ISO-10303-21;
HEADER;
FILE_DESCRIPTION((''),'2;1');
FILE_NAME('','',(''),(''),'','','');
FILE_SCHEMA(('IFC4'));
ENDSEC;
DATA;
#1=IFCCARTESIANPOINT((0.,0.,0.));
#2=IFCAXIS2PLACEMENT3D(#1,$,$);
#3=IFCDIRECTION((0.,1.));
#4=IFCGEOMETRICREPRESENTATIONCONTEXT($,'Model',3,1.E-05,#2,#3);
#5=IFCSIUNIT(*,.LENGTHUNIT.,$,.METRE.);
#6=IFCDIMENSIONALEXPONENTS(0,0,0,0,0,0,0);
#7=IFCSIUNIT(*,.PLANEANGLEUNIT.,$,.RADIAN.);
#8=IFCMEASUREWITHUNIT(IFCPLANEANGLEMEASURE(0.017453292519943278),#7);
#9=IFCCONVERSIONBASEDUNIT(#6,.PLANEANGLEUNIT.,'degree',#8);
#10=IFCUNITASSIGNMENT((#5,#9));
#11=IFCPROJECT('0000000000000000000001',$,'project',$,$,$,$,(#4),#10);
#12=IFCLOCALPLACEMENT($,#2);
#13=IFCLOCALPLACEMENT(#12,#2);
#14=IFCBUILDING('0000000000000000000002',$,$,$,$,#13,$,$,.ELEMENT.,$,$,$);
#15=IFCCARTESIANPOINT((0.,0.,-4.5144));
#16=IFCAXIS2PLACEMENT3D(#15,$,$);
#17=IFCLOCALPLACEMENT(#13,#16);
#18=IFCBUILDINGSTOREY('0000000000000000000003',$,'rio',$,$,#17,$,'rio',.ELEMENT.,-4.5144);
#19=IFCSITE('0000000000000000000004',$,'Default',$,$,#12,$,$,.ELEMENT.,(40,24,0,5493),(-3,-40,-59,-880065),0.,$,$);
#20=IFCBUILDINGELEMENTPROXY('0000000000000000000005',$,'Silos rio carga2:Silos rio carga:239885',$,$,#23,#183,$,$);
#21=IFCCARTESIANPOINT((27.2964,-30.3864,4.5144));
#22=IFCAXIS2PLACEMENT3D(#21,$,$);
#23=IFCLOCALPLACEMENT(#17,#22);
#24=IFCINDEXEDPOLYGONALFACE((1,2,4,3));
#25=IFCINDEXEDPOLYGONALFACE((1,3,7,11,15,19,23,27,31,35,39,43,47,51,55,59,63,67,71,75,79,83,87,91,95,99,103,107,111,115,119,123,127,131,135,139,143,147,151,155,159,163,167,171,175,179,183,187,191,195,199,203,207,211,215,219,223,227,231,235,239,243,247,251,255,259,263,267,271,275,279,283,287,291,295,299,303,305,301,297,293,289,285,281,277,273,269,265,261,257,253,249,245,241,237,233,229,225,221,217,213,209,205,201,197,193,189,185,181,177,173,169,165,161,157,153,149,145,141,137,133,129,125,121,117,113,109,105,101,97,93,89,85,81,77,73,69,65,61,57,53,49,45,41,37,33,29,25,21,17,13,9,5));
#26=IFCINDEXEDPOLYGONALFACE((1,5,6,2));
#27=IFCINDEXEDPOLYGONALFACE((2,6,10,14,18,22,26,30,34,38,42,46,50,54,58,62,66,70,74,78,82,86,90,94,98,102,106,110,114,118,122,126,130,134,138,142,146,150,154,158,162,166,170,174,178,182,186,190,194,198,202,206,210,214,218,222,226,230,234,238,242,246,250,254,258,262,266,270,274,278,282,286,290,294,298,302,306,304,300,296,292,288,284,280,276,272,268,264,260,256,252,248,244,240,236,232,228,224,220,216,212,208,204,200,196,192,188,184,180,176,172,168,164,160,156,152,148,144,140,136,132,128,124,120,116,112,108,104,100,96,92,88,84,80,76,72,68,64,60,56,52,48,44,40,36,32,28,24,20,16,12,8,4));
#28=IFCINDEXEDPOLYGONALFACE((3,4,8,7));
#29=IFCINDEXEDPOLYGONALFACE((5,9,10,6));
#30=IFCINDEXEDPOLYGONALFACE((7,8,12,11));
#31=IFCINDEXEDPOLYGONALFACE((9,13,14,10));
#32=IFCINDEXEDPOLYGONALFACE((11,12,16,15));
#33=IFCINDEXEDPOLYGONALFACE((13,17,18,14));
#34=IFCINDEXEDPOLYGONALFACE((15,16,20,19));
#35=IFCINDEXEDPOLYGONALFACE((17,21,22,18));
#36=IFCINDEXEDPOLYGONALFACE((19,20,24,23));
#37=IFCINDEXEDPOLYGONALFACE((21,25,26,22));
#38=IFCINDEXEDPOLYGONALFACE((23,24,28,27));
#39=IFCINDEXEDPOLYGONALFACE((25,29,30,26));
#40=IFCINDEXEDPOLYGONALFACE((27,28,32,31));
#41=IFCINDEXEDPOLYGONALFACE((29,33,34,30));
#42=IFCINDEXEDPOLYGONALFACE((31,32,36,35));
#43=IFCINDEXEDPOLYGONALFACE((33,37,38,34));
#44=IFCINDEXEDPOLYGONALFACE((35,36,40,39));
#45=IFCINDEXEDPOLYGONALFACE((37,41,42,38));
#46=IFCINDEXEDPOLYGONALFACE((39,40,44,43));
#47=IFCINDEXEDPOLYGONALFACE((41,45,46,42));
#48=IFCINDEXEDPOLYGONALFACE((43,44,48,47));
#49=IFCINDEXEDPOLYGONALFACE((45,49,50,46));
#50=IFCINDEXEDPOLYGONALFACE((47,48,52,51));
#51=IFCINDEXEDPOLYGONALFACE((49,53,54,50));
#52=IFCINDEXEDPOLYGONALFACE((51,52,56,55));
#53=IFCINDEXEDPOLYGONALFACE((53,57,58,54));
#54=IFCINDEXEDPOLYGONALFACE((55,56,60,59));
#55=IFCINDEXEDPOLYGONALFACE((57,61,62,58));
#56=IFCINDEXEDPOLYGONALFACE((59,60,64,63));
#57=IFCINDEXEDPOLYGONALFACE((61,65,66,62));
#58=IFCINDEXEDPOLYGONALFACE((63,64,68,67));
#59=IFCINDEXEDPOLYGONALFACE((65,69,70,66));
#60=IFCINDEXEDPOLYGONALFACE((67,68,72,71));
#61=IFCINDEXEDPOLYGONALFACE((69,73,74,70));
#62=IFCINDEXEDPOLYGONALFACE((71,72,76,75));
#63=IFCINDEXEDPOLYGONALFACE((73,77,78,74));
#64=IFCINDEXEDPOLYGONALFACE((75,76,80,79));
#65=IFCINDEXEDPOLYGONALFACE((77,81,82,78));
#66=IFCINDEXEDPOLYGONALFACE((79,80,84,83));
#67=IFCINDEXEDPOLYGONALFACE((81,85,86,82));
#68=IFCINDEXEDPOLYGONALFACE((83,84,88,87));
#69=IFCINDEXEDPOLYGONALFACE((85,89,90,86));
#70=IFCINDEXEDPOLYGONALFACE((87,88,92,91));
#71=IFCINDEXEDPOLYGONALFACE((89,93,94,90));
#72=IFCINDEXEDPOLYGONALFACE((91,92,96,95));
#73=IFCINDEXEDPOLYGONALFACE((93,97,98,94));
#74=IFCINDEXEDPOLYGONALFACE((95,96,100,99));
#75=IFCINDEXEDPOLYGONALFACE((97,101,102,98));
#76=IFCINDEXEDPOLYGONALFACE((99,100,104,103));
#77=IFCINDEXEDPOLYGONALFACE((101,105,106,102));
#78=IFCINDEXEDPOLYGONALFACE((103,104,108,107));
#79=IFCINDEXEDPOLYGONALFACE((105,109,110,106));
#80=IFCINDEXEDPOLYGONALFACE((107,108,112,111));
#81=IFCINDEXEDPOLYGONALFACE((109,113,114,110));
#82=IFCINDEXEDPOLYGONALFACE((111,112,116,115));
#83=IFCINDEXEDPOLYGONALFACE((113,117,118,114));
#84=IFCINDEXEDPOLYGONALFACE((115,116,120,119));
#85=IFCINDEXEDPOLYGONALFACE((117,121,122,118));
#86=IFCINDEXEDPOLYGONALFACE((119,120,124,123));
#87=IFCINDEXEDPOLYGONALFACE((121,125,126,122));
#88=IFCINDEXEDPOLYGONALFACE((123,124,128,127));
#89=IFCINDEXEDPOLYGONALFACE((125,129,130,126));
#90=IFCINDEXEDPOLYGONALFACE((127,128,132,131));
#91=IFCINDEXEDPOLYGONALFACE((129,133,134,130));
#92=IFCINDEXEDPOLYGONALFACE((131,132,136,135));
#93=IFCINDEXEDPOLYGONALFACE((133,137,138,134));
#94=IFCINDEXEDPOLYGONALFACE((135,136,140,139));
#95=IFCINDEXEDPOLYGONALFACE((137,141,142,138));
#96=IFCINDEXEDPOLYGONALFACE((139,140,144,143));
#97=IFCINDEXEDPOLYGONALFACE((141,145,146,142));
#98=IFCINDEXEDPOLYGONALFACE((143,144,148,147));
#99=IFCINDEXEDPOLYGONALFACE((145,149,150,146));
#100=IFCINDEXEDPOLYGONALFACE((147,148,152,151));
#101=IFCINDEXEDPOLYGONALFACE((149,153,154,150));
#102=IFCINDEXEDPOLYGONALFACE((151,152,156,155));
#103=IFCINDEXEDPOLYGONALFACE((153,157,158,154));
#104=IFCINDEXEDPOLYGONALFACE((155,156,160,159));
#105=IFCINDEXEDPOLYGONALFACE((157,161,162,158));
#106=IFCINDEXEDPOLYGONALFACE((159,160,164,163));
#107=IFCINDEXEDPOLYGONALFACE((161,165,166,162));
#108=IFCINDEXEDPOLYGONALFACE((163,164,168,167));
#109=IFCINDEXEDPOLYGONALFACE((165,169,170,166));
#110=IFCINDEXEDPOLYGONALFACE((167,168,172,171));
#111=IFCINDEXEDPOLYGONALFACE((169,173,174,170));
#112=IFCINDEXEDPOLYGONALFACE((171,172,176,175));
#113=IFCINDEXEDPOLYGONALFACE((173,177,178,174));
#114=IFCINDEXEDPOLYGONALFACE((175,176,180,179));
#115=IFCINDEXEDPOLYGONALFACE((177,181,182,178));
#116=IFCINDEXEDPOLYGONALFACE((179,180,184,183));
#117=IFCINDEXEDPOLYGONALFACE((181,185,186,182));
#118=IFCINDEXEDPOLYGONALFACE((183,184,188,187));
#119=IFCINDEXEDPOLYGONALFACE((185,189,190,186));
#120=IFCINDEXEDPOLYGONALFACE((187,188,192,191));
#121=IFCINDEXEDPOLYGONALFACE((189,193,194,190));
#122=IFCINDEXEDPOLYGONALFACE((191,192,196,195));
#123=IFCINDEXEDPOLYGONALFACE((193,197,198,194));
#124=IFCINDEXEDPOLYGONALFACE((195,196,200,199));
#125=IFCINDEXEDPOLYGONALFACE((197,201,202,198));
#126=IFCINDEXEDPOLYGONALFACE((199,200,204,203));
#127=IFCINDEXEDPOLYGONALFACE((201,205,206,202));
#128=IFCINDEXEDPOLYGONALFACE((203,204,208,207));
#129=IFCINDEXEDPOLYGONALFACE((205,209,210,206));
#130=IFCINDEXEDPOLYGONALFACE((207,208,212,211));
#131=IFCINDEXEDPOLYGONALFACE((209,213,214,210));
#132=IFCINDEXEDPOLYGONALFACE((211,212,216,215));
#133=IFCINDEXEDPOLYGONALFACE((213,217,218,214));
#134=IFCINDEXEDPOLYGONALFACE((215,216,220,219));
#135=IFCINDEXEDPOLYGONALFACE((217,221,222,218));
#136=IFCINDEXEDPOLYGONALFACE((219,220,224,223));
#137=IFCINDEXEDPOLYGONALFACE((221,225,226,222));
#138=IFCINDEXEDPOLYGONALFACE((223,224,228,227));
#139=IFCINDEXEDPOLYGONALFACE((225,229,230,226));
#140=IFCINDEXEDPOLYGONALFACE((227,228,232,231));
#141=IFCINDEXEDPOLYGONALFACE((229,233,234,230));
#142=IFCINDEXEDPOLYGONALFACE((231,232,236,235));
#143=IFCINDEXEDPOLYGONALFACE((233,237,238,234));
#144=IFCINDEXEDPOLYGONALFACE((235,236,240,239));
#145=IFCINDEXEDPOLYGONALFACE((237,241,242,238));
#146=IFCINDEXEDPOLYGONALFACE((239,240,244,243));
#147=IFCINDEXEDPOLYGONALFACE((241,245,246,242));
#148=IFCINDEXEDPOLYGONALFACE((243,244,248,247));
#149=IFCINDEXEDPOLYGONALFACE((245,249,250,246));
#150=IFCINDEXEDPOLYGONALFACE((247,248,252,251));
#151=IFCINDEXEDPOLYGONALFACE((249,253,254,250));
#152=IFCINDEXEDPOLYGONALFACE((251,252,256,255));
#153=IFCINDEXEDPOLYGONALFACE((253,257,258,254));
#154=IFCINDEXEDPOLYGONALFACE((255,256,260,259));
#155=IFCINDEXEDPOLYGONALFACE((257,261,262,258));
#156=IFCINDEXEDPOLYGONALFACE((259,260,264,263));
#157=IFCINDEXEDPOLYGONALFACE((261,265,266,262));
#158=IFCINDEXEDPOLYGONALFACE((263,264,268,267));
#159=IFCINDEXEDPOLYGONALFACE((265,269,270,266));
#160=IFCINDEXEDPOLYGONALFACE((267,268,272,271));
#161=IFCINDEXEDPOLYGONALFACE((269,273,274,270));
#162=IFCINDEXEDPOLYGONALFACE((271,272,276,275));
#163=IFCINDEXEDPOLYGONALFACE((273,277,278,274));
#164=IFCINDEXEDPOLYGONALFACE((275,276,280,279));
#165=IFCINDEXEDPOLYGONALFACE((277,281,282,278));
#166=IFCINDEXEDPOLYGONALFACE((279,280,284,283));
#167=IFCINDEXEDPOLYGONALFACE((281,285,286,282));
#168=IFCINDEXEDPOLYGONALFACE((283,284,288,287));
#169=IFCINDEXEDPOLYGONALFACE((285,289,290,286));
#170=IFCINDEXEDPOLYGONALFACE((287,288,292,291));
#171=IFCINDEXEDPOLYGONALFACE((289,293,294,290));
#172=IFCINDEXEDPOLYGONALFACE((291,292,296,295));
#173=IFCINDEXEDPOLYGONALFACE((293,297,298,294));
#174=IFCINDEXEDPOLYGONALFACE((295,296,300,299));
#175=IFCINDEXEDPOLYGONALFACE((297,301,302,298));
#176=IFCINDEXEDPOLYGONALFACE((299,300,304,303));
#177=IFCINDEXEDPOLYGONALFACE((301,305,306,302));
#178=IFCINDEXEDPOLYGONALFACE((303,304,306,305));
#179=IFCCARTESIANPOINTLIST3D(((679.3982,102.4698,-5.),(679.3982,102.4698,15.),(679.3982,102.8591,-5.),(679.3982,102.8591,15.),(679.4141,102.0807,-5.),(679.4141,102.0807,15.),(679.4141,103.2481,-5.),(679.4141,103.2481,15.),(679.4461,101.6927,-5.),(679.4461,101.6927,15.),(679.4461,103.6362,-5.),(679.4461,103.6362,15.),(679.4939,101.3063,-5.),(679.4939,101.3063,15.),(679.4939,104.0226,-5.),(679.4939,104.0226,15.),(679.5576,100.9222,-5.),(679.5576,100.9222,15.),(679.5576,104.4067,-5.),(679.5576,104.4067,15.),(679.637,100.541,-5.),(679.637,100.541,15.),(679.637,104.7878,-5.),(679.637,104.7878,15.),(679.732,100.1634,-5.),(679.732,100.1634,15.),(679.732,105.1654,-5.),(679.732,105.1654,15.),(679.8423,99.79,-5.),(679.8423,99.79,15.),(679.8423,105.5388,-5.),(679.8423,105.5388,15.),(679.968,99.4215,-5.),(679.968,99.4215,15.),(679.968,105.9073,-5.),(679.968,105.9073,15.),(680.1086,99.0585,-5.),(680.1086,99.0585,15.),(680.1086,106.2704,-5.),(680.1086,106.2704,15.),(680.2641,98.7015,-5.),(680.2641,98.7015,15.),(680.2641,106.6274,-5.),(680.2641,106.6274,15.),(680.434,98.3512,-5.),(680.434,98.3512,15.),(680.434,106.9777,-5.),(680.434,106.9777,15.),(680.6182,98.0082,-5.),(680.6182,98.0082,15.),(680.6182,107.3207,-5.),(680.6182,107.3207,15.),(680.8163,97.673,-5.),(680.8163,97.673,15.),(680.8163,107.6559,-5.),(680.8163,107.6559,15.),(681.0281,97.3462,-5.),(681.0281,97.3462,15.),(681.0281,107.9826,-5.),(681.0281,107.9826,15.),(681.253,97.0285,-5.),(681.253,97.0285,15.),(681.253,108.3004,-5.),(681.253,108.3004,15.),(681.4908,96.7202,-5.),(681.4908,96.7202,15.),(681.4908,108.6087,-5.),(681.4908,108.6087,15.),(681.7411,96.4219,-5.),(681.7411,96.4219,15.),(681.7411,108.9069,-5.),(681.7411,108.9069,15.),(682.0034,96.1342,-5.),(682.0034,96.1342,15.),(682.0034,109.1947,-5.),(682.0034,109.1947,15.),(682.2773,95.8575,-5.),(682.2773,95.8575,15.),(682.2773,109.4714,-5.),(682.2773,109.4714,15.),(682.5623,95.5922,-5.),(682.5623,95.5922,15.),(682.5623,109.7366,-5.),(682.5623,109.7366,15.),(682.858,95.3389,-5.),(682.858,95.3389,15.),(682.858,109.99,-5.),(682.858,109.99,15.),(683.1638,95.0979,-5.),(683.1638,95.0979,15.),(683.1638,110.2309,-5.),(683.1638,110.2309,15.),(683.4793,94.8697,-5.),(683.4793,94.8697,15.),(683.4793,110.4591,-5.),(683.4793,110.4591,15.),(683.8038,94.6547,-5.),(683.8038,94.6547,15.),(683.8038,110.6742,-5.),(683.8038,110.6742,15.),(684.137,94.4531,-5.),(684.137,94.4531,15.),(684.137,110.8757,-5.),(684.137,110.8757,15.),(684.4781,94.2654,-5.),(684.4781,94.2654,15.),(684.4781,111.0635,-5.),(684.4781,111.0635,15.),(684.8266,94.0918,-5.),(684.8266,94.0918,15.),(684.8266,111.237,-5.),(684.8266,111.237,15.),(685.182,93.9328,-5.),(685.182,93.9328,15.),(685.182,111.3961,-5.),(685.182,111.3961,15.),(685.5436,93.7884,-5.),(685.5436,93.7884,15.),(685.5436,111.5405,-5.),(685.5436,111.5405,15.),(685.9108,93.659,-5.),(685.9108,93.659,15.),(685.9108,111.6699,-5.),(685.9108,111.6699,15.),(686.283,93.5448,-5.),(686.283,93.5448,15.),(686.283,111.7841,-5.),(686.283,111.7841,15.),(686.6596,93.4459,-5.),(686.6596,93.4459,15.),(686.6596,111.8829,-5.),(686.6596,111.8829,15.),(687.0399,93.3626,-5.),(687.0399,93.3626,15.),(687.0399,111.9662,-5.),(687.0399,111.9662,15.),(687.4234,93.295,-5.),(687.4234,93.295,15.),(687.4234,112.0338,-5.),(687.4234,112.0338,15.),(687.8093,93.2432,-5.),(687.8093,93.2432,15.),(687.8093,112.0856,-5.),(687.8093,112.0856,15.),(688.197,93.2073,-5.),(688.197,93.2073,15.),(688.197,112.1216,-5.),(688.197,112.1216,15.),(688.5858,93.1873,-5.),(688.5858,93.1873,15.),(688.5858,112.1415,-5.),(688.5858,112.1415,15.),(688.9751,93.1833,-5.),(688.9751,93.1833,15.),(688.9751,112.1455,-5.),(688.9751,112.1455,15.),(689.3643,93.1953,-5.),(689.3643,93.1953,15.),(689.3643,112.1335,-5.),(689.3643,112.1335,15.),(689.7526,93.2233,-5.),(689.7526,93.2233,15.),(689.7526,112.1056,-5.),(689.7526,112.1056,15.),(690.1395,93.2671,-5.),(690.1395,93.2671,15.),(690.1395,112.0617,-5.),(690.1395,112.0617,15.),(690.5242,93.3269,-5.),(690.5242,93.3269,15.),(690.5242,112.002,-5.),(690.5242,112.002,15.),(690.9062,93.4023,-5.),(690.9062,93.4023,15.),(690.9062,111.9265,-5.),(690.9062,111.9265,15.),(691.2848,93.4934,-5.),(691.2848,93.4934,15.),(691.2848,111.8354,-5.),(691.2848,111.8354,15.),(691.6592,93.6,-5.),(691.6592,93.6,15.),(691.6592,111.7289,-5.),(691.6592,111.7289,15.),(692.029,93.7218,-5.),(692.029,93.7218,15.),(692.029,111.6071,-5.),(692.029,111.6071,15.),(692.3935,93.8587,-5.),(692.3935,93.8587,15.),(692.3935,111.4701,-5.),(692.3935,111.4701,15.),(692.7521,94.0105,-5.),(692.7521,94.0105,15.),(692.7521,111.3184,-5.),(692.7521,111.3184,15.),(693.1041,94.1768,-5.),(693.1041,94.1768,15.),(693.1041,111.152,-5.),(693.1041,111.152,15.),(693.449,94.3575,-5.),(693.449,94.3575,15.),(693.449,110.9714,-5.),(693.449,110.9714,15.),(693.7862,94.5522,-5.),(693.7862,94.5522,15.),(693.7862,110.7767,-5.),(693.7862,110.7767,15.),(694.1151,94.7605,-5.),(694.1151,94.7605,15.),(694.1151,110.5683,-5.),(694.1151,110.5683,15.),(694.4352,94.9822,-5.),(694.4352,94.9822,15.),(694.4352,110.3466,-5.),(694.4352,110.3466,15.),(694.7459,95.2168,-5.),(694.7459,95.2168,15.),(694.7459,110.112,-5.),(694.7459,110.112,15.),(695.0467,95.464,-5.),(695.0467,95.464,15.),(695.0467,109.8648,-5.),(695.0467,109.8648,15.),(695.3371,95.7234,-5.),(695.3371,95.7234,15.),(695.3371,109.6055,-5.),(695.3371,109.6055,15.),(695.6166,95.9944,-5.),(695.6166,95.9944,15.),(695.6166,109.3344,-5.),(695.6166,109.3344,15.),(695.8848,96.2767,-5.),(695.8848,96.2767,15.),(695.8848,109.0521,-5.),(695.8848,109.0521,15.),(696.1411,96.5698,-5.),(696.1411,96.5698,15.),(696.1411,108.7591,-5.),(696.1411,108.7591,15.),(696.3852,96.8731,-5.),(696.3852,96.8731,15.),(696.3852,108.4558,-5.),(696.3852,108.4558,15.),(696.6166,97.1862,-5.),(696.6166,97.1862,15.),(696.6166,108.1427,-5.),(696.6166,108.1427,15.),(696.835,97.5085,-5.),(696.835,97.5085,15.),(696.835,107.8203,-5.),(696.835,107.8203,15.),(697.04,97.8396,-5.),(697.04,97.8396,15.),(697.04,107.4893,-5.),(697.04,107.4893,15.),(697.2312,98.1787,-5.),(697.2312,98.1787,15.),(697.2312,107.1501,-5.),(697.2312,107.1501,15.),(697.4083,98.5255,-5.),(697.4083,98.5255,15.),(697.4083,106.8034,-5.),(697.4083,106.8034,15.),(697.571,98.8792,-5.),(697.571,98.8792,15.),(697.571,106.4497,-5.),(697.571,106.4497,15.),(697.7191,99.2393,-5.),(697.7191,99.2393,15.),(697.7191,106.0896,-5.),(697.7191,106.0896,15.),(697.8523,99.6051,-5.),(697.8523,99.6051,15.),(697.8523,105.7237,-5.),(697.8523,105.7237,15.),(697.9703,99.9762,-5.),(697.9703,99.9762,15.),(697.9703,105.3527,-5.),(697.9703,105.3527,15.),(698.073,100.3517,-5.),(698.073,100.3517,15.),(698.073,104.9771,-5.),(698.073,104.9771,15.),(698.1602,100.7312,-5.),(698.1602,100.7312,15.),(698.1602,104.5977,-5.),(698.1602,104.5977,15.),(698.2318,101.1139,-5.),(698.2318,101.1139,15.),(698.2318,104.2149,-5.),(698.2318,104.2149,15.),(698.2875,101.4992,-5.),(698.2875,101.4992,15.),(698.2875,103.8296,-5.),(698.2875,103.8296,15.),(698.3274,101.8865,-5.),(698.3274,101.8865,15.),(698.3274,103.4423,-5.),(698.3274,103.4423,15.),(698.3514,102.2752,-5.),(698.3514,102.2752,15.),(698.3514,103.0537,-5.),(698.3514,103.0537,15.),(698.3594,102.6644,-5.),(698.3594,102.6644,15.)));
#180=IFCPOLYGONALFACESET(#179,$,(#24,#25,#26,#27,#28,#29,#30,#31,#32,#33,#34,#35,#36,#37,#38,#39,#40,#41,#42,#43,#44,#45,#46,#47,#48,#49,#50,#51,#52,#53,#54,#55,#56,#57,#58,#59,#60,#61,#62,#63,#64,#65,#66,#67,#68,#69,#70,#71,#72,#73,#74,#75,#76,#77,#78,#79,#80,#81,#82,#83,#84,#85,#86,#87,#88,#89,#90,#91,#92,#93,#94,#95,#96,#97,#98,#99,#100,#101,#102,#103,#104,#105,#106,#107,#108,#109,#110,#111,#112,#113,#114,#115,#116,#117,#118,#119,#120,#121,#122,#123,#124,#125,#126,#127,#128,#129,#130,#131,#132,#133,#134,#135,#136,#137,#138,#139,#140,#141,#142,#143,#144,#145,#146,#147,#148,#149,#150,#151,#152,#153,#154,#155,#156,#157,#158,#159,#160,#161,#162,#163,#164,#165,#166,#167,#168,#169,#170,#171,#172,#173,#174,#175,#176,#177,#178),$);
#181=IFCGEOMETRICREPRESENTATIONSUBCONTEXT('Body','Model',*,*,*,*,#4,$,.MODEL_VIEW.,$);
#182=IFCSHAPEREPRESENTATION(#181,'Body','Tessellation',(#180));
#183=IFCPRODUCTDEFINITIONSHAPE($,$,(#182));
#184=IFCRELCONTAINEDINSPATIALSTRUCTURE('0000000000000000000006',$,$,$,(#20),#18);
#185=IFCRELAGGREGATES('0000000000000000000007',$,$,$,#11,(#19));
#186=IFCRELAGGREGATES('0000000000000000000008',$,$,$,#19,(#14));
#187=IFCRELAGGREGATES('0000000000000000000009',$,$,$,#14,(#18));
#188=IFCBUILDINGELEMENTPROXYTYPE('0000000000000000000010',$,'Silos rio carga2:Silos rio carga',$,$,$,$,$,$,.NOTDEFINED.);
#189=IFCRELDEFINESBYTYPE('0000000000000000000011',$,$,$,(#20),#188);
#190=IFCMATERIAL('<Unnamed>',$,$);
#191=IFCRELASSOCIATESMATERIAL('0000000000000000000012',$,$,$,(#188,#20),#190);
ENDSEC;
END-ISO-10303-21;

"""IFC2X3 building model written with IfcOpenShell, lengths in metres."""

from ifc_helpers import new_model, entity, si_unit, converted_unit, direction, frame, frame_2d, origin, place, context, subcontext, project, spatial, circle, extrude, source, transform, mapped, material, type_object, type_shapes, element, save


model = new_model("IFC2X3")

# Units and contexts
model_context = context("Model", 3, precision=1e-05, world=origin(), true_north=direction((0.0, 1.0)))
body_context = subcontext(model_context, "Body", "Model", "MODEL_VIEW")
ifc_project = project(units=[si_unit("LENGTHUNIT", "METRE"), converted_unit("PLANEANGLEUNIT", "degree", entity("IfcPlaneAngleMeasure", 0.017453292519943278), si_unit("PLANEANGLEUNIT", "RADIAN"), dimensions=[0, 0, 0, 0, 0, 0, 0])], contexts=[model_context])

# Site, building, storey
site_placement = place(None, origin())
site = spatial("IfcSite", under=ifc_project, at=site_placement, Name="Default", CompositionType="ELEMENT", RefLatitude=(40, 24, 0, 5493), RefLongitude=(-3, -40, -59, -880065), RefElevation=0.0)
building_placement = place(site_placement, origin())
building = spatial("IfcBuilding", under=site, at=building_placement, CompositionType="ELEMENT")
storey_placement = place(building_placement, frame((0.0, 0.0, -4.5144)))
storey = spatial("IfcBuildingStorey", under=building, at=storey_placement, Name="rio", LongName="rio", CompositionType="ELEMENT", Elevation=-4.5144)

# Building element proxy
ifc_material_1 = material(Name="<Unnamed>")
building_element_proxy_type_1 = type_object("IfcBuildingElementProxyType", Name="Silos rio carga2:Silos rio carga", PredefinedType="NOTDEFINED", material=ifc_material_1)
shared_shape_1 = source(origin(), body_context, "Body", "SweptSolid", [
    extrude(circle(Radius=9.4816, at=frame_2d((0.0, 0.0), x_axis=(1.0, 0.0))), frame((688.8778, 102.6644, -5.0)), (0.0, 0.0, 1.0), 20.0),
])
type_shapes(building_element_proxy_type_1, [shared_shape_1])
proxy_1_placement = place(storey_placement, frame((27.2964, -30.3864, 4.5144)))
element("IfcBuildingElementProxy", 1, at=proxy_1_placement, inside=storey, type_object=building_element_proxy_type_1, material=ifc_material_1, Name="Silos rio carga2:Silos rio carga:239885", context=body_context, shape_type="MappedRepresentation", body=[
    mapped(shared_shape_1, transform((0.0, 0.0, 0.0), scale=1.0)),
])

save(model, "model.ifc")
